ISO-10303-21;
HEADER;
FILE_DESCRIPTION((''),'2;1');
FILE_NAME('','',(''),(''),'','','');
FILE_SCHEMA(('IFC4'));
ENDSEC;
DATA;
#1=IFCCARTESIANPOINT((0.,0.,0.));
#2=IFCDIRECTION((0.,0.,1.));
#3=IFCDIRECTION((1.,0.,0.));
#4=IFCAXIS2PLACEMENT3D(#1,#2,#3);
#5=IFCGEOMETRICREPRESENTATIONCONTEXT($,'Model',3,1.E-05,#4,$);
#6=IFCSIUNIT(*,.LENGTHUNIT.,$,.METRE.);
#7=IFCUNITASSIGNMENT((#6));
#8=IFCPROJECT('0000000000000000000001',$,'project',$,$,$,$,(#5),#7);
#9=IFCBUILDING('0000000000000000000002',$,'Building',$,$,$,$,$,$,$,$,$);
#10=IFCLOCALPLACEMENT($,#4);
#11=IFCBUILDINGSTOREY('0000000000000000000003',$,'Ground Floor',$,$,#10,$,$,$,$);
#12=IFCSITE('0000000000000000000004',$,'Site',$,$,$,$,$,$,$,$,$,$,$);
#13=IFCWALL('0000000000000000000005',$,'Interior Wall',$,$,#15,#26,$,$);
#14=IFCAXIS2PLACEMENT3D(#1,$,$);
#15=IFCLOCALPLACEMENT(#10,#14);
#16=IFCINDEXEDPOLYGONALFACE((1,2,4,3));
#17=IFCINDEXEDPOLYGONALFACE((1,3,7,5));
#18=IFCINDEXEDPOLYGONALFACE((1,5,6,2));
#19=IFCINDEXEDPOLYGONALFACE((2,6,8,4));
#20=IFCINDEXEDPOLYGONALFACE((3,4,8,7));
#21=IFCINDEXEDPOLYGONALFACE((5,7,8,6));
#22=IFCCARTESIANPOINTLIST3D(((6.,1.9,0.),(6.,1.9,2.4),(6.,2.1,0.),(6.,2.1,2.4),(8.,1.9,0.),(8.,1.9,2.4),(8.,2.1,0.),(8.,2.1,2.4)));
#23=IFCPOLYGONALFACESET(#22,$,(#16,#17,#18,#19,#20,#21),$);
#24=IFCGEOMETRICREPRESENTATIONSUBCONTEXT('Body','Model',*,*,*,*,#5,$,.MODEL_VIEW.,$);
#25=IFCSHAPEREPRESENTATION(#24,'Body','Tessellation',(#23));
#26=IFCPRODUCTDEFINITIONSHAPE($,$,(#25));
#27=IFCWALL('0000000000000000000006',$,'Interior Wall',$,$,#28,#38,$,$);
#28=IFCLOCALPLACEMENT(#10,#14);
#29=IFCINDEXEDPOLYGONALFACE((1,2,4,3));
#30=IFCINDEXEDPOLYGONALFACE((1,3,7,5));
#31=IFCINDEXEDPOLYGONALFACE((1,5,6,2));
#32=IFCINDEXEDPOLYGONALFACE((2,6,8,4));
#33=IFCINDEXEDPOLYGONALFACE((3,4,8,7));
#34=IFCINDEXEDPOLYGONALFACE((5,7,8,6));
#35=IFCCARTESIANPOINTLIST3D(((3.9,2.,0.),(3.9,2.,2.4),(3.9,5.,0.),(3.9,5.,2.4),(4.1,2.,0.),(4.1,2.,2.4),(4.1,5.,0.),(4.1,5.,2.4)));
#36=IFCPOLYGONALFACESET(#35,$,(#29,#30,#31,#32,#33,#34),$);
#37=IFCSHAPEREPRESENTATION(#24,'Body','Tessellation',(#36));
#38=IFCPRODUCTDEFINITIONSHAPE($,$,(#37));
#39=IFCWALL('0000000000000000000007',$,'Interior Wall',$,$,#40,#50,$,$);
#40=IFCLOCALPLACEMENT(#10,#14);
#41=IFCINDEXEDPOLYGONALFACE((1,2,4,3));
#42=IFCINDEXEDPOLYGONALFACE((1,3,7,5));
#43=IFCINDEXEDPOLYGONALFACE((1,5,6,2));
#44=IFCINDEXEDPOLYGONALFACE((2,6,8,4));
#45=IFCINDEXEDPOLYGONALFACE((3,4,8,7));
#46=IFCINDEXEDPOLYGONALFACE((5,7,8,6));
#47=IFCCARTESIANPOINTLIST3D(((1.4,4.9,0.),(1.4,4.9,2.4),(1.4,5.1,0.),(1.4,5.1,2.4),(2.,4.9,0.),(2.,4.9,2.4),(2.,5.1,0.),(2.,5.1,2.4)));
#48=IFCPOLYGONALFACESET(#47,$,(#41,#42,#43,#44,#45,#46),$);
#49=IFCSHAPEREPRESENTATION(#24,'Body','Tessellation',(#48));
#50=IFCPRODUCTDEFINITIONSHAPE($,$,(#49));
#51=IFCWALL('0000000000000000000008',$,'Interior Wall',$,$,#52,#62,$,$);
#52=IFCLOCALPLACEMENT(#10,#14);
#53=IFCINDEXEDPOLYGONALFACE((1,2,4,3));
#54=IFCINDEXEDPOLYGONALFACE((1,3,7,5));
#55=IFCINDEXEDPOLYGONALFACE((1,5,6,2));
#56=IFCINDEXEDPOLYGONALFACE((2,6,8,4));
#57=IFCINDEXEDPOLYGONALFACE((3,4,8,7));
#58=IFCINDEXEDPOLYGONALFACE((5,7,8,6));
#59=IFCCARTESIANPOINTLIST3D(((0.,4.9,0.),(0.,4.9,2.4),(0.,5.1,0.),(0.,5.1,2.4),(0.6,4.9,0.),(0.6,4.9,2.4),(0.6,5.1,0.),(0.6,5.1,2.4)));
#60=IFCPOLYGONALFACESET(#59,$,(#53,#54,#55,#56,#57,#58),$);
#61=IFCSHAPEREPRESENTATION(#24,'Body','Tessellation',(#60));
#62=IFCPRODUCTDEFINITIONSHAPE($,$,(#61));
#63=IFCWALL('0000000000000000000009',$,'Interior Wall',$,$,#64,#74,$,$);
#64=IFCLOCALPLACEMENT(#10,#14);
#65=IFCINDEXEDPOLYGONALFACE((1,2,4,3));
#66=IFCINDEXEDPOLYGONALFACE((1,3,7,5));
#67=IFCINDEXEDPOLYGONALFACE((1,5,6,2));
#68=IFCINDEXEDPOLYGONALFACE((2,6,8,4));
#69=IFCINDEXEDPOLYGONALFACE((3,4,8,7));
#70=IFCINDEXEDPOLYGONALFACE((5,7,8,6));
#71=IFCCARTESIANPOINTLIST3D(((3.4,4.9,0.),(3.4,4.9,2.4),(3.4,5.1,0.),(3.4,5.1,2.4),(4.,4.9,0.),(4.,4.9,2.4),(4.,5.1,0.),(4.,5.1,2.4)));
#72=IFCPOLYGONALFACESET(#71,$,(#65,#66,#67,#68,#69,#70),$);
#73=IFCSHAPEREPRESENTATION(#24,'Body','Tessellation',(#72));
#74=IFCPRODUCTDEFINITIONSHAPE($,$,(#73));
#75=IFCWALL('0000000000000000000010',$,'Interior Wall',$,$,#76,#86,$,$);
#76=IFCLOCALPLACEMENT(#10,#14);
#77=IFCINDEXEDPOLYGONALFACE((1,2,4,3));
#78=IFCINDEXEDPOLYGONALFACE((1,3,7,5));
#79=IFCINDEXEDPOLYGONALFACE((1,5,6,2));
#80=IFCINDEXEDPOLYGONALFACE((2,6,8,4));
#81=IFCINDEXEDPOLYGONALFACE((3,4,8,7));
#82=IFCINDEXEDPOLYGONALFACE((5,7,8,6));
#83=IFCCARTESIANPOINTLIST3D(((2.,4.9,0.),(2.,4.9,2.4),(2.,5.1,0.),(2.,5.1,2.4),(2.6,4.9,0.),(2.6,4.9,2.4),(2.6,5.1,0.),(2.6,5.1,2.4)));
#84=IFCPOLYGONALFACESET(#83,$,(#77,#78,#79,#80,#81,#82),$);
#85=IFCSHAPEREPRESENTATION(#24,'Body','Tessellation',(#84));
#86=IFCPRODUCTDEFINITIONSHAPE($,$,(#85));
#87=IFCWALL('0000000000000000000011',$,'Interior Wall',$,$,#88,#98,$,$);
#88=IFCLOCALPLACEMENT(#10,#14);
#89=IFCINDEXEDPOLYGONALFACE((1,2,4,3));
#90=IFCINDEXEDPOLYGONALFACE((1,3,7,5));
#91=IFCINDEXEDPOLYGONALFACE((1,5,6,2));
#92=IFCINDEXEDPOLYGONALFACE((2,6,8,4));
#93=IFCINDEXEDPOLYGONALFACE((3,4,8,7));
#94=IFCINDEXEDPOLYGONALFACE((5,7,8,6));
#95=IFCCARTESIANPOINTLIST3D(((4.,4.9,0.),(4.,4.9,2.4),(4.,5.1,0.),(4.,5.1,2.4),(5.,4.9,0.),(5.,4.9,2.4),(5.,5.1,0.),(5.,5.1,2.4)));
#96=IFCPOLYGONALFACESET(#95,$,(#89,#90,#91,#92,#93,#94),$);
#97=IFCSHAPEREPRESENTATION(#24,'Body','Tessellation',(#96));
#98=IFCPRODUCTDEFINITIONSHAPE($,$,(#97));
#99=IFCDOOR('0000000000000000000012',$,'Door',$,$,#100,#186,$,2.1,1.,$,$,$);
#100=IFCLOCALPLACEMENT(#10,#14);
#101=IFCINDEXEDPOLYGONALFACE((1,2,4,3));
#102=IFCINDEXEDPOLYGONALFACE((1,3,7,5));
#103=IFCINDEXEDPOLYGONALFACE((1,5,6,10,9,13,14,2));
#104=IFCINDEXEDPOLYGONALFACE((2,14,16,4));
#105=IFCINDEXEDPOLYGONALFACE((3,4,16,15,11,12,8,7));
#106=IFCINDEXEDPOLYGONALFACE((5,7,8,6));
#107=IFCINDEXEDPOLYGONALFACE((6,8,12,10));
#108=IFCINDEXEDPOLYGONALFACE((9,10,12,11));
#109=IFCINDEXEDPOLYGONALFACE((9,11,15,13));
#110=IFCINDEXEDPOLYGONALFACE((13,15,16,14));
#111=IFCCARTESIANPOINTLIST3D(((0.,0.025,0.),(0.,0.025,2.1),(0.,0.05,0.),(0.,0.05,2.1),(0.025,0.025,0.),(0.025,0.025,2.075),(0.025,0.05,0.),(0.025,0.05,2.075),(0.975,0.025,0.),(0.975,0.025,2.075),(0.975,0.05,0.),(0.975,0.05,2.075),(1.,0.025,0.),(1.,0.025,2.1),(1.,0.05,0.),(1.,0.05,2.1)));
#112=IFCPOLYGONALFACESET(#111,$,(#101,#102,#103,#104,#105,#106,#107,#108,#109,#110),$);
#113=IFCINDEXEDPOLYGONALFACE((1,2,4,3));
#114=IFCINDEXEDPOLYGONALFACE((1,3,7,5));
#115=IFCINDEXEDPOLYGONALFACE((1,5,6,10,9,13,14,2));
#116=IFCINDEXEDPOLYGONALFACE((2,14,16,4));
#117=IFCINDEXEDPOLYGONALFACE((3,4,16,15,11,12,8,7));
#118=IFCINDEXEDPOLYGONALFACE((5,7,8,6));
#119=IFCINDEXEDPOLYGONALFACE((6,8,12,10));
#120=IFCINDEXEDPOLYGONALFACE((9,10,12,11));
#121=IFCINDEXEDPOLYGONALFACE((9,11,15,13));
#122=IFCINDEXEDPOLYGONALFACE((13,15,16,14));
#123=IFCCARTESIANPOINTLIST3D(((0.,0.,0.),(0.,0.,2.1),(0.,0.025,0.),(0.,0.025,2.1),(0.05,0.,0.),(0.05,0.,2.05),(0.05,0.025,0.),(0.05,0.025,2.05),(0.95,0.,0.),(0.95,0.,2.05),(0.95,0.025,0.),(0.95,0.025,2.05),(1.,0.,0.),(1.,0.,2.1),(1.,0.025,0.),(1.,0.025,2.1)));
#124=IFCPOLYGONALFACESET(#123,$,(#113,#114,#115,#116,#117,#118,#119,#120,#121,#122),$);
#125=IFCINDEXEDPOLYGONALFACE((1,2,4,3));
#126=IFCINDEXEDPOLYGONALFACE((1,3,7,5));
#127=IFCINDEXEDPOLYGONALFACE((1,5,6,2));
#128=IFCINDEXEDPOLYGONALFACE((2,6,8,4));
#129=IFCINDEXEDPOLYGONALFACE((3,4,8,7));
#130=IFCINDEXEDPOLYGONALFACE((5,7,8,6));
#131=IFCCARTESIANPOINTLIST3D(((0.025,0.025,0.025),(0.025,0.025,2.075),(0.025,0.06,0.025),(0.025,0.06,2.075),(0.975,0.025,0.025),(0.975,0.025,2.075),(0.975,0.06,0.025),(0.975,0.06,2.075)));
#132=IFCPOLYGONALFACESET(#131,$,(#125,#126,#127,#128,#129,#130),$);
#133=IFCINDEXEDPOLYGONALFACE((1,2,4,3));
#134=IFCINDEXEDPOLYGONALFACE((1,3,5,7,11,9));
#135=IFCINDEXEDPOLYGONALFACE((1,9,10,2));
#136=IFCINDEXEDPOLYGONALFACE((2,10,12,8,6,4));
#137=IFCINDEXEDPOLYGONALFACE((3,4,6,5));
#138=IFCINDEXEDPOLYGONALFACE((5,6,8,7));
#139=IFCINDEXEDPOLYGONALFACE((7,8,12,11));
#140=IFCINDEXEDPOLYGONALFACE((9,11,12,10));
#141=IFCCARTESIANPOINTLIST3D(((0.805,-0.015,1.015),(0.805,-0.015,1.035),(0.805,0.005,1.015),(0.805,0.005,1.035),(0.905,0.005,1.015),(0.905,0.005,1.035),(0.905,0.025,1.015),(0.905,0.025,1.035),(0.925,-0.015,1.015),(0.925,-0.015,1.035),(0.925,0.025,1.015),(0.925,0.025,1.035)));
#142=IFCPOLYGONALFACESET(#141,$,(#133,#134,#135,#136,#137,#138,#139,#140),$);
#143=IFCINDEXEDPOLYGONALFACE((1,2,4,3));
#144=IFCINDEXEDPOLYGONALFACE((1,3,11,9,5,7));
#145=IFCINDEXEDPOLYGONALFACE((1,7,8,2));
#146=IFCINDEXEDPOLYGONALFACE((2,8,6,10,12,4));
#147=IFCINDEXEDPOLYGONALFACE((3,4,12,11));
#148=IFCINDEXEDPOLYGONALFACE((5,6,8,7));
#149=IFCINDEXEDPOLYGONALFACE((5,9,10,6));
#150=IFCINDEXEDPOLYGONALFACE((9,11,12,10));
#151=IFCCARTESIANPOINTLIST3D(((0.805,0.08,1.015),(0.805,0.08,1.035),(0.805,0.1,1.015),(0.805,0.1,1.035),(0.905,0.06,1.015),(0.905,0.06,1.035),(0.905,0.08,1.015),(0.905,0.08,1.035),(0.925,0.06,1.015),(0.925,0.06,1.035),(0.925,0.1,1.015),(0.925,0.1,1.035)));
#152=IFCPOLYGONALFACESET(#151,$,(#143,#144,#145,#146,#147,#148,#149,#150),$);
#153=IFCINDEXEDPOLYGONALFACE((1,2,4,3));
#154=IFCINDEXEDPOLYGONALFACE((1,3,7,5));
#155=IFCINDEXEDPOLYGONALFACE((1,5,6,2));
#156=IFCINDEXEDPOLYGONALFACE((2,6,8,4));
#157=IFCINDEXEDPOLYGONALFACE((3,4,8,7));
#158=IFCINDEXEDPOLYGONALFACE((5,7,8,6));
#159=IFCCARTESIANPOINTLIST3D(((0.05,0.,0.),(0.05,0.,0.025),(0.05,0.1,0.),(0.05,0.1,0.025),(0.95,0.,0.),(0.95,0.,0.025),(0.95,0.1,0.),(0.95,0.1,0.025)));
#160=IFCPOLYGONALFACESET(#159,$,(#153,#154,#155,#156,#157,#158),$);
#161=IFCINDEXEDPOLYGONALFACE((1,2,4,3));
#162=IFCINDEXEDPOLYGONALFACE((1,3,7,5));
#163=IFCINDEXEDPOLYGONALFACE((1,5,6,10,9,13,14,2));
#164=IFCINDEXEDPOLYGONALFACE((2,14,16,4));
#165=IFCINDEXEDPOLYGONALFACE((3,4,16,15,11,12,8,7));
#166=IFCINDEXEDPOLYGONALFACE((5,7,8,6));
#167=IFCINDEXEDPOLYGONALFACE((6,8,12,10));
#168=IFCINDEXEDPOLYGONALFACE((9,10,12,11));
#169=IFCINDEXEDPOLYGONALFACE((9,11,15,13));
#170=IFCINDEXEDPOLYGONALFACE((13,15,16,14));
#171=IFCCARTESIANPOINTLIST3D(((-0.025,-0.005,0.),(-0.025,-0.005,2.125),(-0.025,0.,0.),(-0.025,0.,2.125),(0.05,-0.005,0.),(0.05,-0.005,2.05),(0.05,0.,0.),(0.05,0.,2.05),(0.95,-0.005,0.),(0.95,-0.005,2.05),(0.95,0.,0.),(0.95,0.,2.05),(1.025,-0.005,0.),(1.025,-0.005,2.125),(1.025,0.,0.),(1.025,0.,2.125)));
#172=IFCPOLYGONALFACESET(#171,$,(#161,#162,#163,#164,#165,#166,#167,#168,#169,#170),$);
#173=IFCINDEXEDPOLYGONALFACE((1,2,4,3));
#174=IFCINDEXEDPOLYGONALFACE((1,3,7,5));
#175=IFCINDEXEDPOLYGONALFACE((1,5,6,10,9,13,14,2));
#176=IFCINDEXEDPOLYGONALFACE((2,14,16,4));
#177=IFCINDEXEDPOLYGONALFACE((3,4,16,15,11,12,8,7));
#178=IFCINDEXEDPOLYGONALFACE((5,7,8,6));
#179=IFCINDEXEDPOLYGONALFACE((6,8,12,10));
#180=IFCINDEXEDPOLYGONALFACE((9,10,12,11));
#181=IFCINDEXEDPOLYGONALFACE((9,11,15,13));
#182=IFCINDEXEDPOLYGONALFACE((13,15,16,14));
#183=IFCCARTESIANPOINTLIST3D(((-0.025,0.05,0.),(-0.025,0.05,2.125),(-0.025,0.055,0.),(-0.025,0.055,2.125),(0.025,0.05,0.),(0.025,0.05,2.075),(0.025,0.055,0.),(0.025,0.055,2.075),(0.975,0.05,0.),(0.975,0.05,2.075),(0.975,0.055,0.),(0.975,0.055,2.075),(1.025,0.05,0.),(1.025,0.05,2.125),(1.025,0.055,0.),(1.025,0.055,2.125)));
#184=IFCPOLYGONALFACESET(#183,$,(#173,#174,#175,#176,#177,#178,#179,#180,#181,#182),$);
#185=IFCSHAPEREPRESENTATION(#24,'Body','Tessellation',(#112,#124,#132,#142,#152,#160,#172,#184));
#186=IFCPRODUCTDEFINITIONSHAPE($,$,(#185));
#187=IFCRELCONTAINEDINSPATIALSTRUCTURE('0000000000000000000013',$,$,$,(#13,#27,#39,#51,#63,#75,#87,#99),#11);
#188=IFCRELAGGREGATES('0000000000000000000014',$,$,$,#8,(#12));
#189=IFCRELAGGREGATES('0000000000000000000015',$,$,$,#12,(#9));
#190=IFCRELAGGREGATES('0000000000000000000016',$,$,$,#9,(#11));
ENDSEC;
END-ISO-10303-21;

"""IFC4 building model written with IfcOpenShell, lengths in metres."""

from ifc_helpers import new_model, si_unit, frame, origin_with_axes, place, context, subcontext, project, spatial, line, indexed_curve, outline, extrude, element, save


model = new_model("IFC4")

# Units and contexts
model_context = context("Model", 3, precision=1e-05, world=origin_with_axes())
body_context = subcontext(model_context, "Body", "Model", "MODEL_VIEW")
ifc_project = project(units=[si_unit("LENGTHUNIT", "METRE")], contexts=[model_context])

# Site, building, storey
site = spatial("IfcSite", under=ifc_project, Name="Site")
building = spatial("IfcBuilding", under=site, Name="Building")
storey_placement = place(None, origin_with_axes())
storey = spatial("IfcBuildingStorey", under=building, at=storey_placement, Name="Ground Floor")

# Walls
wall_1_placement = place(storey_placement, frame((8.0, 2.0, 0.0), z_axis=(0.0, 0.0, 1.0), x_axis=(-1.0, 0.0, 0.0)))
element("IfcWall", 1, at=wall_1_placement, inside=storey, Name="Interior Wall", context=body_context, shape_type="SweptSolid", body=[
    extrude(outline(indexed_curve([(0.0, 0.0), (0.0, 0.2), (2.0, 0.2), (2.0, 0.0), (0.0, 0.0)], self_intersect=False)), frame((0.0, -0.1, 0.0), z_axis=(0.0, 0.0, 1.0), x_axis=(1.0, 0.0, 0.0)), (0.0, 0.0, 1.0), 2.4),
])
wall_2_placement = place(storey_placement, frame((4.0, 2.0, 0.0), z_axis=(0.0, 0.0, 1.0), x_axis=(0.0, 1.0, 0.0)))
element("IfcWall", 2, at=wall_2_placement, inside=storey, Name="Interior Wall", context=body_context, shape_type="SweptSolid", body=[
    extrude(outline(indexed_curve([(0.0, 0.0), (0.0, 0.2), (3.0, 0.2), (3.0, 0.0), (0.0, 0.0)], self_intersect=False)), frame((0.0, -0.1, 0.0), z_axis=(0.0, 0.0, 1.0), x_axis=(1.0, 0.0, 0.0)), (0.0, 0.0, 1.0), 2.4),
])
for number, where, z_axis, x_axis, name in (
    (3, (2.0, 5.0, 0.0), (0.0, 0.0, 1.0), (-1.0, 0.0, 0.0), "Interior Wall"),
    (4, (0.6, 5.0, 0.0), (0.0, 0.0, 1.0), (-1.0, 0.0, 0.0), "Interior Wall"),
    (5, (4.0, 5.0, 0.0), (0.0, 0.0, 1.0), (-1.0, 0.0, 0.0), "Interior Wall"),
    (6, (2.6, 5.0, 0.0), (0.0, 0.0, 1.0), (-1.0, 0.0, 0.0), "Interior Wall"),
):
    element("IfcWall", number, at=place(storey_placement, frame(where, z_axis=z_axis, x_axis=x_axis)), inside=storey, Name=name, context=body_context, shape_type="SweptSolid", body=[
        extrude(outline(indexed_curve([(0.0, 0.0), (0.0, 0.2), (0.6, 0.2), (0.6, 0.0), (0.0, 0.0)], self_intersect=False)), frame((0.0, -0.1, 0.0), z_axis=(0.0, 0.0, 1.0), x_axis=(1.0, 0.0, 0.0)), (0.0, 0.0, 1.0), 2.4),
    ])
wall_3_placement = place(storey_placement, frame((5.0, 5.0, 0.0), z_axis=(0.0, 0.0, 1.0), x_axis=(-1.0, 0.0, 0.0)))
element("IfcWall", 7, at=wall_3_placement, inside=storey, Name="Interior Wall", context=body_context, shape_type="SweptSolid", body=[
    extrude(outline(indexed_curve([(0.0, 0.0), (0.0, 0.2), (1.0, 0.2), (1.0, 0.0), (0.0, 0.0)], self_intersect=False)), frame((0.0, -0.1, 0.0), z_axis=(0.0, 0.0, 1.0), x_axis=(1.0, 0.0, 0.0)), (0.0, 0.0, 1.0), 2.4),
])

# Door
door_1_placement = place(storey_placement, origin_with_axes())
element("IfcDoor", 8, at=door_1_placement, inside=storey, Name="Door", OverallHeight=2.1, OverallWidth=1.0, context=body_context, shape_type="SweptSolid", body=[
    extrude(outline(indexed_curve([(0.0, 0.0), (0.0, 2.1), (1.0, 2.1), (1.0, 0.0), (0.975, 0.0), (0.975, 2.075), (0.025, 2.075), (0.025, 0.0)], segments=[line(1, 2, 3, 4, 5, 6, 7, 8, 1)])), frame((0.0, 0.025, 0.0), z_axis=(0.0, -1.0, 0.0), x_axis=(1.0, 0.0, 0.0)), (0.0, 0.0, -1.0), 0.025),
    extrude(outline(indexed_curve([(0.0, 0.0), (0.0, 2.1), (1.0, 2.1), (1.0, 0.0), (0.95, 0.0), (0.95, 2.05), (0.05, 2.05), (0.05, 0.0)], segments=[line(1, 2, 3, 4, 5, 6, 7, 8, 1)])), frame((0.0, 0.0, 0.0), z_axis=(0.0, -1.0, 0.0), x_axis=(1.0, 0.0, 0.0)), (0.0, 0.0, -1.0), 0.025),
    extrude(outline(indexed_curve([(0.0, 0.0), (0.95, 0.0), (0.95, 0.035), (0.0, 0.035)], segments=[line(1, 2, 3, 4, 1)])), frame((0.025, 0.025, 0.025), z_axis=(0.0, 0.0, 1.0), x_axis=(1.0, 0.0, 0.0)), (0.0, 0.0, 1.0), 2.05),
    extrude(outline(indexed_curve([(0.0, 0.0), (0.0, -0.04), (-0.12, -0.04), (-0.12, -0.02), (-0.02, -0.02), (-0.02, 0.0)], segments=[line(1, 2, 3, 4, 5, 6, 1)])), frame((0.925, 0.025, 1.015), z_axis=(0.0, 0.0, 1.0), x_axis=(1.0, 0.0, 0.0)), (0.0, 0.0, 1.0), 0.02),
    extrude(outline(indexed_curve([(0.0, 0.0), (0.0, 0.04), (-0.12, 0.04), (-0.12, 0.02), (-0.02, 0.02), (-0.02, 0.0)], segments=[line(1, 2, 3, 4, 5, 6, 1)])), frame((0.925, 0.06, 1.015), z_axis=(0.0, 0.0, 1.0), x_axis=(1.0, 0.0, 0.0)), (0.0, 0.0, 1.0), 0.02),
    extrude(outline(indexed_curve([(0.0, 0.0), (0.9, 0.0), (0.9, 0.1), (0.0, 0.1)], segments=[line(1, 2, 3, 4, 1)])), frame((0.05, 0.0, 0.0), z_axis=(0.0, 0.0, 1.0), x_axis=(1.0, 0.0, 0.0)), (0.0, 0.0, 1.0), 0.025),
    extrude(outline(indexed_curve([(0.0, 0.0), (0.0, 2.125), (1.05, 2.125), (1.05, 0.0), (0.975, 0.0), (0.975, 2.05), (0.075, 2.05), (0.075, 0.0)], segments=[line(1, 2, 3, 4, 5, 6, 7, 8, 1)])), frame((-0.025, -0.005, 0.0), z_axis=(0.0, -1.0, 0.0), x_axis=(1.0, 0.0, 0.0)), (0.0, 0.0, -1.0), 0.005),
    extrude(outline(indexed_curve([(0.0, 0.0), (0.0, 2.125), (1.05, 2.125), (1.05, 0.0), (1.0, 0.0), (1.0, 2.075), (0.05, 2.075), (0.05, 0.0)], segments=[line(1, 2, 3, 4, 5, 6, 7, 8, 1)])), frame((-0.025, 0.05, 0.0), z_axis=(0.0, -1.0, 0.0), x_axis=(1.0, 0.0, 0.0)), (0.0, 0.0, -1.0), 0.005),
])

save(model, "model.ifc")
